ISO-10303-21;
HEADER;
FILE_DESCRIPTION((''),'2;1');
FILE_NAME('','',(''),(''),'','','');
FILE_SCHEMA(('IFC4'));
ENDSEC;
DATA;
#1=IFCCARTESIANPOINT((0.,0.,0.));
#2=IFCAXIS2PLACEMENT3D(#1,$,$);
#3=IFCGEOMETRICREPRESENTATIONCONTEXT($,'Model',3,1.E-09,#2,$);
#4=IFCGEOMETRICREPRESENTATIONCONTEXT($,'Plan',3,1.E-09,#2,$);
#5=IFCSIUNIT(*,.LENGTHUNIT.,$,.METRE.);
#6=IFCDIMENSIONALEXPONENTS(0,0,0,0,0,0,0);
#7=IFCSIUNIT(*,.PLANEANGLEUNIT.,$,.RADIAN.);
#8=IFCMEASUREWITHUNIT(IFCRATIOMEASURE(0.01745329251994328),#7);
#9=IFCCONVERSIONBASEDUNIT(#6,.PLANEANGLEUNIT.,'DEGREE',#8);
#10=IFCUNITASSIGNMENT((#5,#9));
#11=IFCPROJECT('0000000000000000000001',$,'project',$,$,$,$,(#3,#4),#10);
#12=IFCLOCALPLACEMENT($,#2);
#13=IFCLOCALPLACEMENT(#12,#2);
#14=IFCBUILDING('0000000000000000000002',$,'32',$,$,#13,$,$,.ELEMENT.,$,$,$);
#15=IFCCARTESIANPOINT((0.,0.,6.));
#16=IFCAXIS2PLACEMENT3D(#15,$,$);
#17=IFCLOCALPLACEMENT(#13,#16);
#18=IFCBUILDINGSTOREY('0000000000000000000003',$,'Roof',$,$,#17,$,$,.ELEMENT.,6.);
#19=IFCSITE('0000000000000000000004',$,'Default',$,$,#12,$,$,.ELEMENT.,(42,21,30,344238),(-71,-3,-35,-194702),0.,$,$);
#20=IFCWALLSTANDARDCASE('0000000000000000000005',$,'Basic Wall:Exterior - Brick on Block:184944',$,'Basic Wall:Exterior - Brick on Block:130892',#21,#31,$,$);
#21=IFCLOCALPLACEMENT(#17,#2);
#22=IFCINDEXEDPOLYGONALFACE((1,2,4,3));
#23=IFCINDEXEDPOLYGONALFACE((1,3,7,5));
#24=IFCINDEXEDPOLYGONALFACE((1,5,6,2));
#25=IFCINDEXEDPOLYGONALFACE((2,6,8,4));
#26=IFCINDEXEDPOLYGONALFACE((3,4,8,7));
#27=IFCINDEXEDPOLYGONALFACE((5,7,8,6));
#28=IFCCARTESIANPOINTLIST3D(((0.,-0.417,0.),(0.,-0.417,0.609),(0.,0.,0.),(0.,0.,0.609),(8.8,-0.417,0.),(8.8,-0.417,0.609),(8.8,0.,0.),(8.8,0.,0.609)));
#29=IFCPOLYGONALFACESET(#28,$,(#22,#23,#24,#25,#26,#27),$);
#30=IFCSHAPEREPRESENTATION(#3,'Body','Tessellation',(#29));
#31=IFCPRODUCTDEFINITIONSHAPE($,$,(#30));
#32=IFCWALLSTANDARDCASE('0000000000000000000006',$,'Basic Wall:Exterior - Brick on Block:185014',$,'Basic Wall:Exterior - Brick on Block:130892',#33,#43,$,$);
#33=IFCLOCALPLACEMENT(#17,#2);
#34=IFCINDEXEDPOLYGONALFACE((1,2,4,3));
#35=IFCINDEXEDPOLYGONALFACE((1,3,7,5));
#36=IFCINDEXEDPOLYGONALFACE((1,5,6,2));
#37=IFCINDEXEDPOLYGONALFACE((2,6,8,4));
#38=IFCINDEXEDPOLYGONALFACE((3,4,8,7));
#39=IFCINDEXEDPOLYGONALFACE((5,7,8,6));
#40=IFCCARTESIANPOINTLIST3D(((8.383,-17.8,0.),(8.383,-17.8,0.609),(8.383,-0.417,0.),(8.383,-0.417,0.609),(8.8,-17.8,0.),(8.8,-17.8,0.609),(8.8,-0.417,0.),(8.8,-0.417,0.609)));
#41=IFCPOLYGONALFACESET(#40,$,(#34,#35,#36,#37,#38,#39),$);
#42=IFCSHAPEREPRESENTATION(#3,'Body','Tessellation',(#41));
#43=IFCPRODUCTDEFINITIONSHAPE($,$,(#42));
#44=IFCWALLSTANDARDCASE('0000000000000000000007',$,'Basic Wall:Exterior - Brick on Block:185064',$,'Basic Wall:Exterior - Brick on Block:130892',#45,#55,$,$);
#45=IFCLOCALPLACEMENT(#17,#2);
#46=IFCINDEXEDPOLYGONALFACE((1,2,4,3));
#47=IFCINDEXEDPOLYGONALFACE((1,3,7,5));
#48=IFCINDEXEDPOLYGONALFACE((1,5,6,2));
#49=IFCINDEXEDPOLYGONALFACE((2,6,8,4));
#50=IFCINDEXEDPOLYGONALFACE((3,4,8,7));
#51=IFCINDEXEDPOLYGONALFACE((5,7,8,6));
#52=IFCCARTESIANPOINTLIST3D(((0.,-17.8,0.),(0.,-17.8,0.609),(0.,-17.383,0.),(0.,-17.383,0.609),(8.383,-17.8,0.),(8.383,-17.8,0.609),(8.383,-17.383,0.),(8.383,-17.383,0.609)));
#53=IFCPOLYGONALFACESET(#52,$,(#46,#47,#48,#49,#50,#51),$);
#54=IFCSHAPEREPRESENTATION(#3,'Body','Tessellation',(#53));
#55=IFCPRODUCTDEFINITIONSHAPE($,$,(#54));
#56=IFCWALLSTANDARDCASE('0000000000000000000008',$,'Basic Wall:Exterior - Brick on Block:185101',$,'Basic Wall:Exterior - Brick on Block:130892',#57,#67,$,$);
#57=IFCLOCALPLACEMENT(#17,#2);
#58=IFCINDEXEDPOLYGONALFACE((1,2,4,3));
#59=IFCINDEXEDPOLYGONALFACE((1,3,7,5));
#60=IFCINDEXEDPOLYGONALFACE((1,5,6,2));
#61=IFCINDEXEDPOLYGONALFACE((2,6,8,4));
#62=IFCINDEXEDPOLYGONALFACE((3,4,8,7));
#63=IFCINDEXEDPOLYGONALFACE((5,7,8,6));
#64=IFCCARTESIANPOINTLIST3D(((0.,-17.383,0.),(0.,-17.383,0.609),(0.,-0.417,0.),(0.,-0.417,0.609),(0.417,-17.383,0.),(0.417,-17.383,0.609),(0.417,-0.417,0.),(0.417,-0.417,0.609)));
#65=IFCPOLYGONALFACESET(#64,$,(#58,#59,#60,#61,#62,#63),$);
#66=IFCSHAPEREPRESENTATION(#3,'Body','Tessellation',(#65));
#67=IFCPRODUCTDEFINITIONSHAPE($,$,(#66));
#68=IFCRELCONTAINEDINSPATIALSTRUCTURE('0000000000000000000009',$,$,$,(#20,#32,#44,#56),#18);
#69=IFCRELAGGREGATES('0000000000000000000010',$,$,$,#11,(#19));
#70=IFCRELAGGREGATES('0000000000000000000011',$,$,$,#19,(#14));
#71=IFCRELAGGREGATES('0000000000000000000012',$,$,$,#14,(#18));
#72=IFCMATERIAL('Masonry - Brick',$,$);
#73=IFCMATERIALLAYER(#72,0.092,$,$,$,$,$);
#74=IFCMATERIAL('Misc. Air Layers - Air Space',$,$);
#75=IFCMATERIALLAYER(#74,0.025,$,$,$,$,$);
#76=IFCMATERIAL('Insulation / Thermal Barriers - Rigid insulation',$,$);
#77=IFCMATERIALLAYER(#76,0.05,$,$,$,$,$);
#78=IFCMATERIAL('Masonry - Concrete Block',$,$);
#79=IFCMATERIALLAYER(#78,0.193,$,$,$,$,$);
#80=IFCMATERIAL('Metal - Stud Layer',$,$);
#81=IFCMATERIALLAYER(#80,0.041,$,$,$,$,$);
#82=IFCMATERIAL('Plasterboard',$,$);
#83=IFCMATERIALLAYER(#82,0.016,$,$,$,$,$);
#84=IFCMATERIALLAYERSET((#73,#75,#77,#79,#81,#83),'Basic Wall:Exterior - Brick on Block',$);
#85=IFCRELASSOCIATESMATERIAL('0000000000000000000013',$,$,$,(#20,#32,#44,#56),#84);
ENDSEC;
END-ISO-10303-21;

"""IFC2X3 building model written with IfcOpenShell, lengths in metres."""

from ifc_helpers import new_model, entity, si_unit, converted_unit, frame, frame_2d, origin, place, context, project, spatial, rectangle, extrude, material, layer, layer_set, layer_usage, element, save


model = new_model("IFC2X3")

# Units and contexts
model_context = context("Model", 3, precision=1e-09, world=origin())
plan_context = context("Plan", 3, precision=1e-09, world=origin())
ifc_project = project(units=[si_unit("LENGTHUNIT", "METRE"), converted_unit("PLANEANGLEUNIT", "DEGREE", entity("IfcRatioMeasure", 0.01745329251994328), si_unit("PLANEANGLEUNIT", "RADIAN"), dimensions=[0, 0, 0, 0, 0, 0, 0])], contexts=[model_context, plan_context])

# Site, building, storey
site_placement = place(None, origin())
site = spatial("IfcSite", under=ifc_project, at=site_placement, Name="Default", CompositionType="ELEMENT", RefLatitude=(42, 21, 30, 344238), RefLongitude=(-71, -3, -35, -194702), RefElevation=0.0)
building_placement = place(site_placement, origin())
building = spatial("IfcBuilding", under=site, at=building_placement, Name="32", CompositionType="ELEMENT")
storey_placement = place(building_placement, frame((0.0, 0.0, 6.0)))
storey = spatial("IfcBuildingStorey", under=building, at=storey_placement, Name="Roof", CompositionType="ELEMENT", Elevation=6.0)

# Walls
ifc_material_1 = material(Name="Masonry - Brick")
ifc_layer_1 = layer(ifc_material_1, 0.092)
ifc_material_2 = material(Name="Misc. Air Layers - Air Space")
ifc_layer_2 = layer(ifc_material_2, 0.025)
ifc_material_3 = material(Name="Insulation / Thermal Barriers - Rigid insulation")
ifc_layer_3 = layer(ifc_material_3, 0.05)
ifc_material_4 = material(Name="Masonry - Concrete Block")
ifc_layer_4 = layer(ifc_material_4, 0.193)
ifc_material_5 = material(Name="Metal - Stud Layer")
ifc_layer_5 = layer(ifc_material_5, 0.041)
ifc_material_6 = material(Name="Plasterboard")
ifc_layer_6 = layer(ifc_material_6, 0.016)
ifc_layer_set = layer_set([ifc_layer_1, ifc_layer_2, ifc_layer_3, ifc_layer_4, ifc_layer_5, ifc_layer_6], Name="Basic Wall:Exterior - Brick on Block")
ifc_layer_usage_1 = layer_usage(ifc_layer_set, "AXIS2", "NEGATIVE", 0.2085)
wall_1_placement = place(storey_placement, frame((0.0, -0.2085, 0.0)))
element("IfcWallStandardCase", 1, at=wall_1_placement, inside=storey, material=ifc_layer_usage_1, Name="Basic Wall:Exterior - Brick on Block:184944", ObjectType="Basic Wall:Exterior - Brick on Block:130892", context=model_context, shape_type="SweptSolid", body=[
    extrude(rectangle(XDim=8.8, YDim=0.417, at=frame_2d((4.4, 0.0), x_axis=(-1.0, 0.0))), origin(), (0.0, 0.0, 1.0), 0.609),
])
ifc_layer_usage_2 = layer_usage(ifc_layer_set, "AXIS2", "NEGATIVE", 0.2085)
wall_2_placement = place(storey_placement, frame((8.5915, -0.417, 0.0), z_axis=(0.0, 0.0, 1.0), x_axis=(0.0, -1.0, 0.0)))
element("IfcWallStandardCase", 2, at=wall_2_placement, inside=storey, material=ifc_layer_usage_2, Name="Basic Wall:Exterior - Brick on Block:185014", ObjectType="Basic Wall:Exterior - Brick on Block:130892", context=model_context, shape_type="SweptSolid", body=[
    extrude(rectangle(XDim=17.383, YDim=0.417, at=frame_2d((8.6915, 0.0), x_axis=(-1.0, 0.0))), origin(), (0.0, 0.0, 1.0), 0.609),
])
ifc_layer_usage_3 = layer_usage(ifc_layer_set, "AXIS2", "NEGATIVE", 0.2085)
wall_3_placement = place(storey_placement, frame((8.383, -17.5915, 0.0), z_axis=(0.0, 0.0, 1.0), x_axis=(-1.0, 0.0, 0.0)))
element("IfcWallStandardCase", 3, at=wall_3_placement, inside=storey, material=ifc_layer_usage_3, Name="Basic Wall:Exterior - Brick on Block:185064", ObjectType="Basic Wall:Exterior - Brick on Block:130892", context=model_context, shape_type="SweptSolid", body=[
    extrude(rectangle(XDim=8.383, YDim=0.417, at=frame_2d((4.1915, 0.0), x_axis=(-1.0, 0.0))), origin(), (0.0, 0.0, 1.0), 0.609),
])
ifc_layer_usage_4 = layer_usage(ifc_layer_set, "AXIS2", "NEGATIVE", 0.2085)
wall_4_placement = place(storey_placement, frame((0.2085, -17.383, 0.0), z_axis=(0.0, 0.0, 1.0), x_axis=(0.0, 1.0, 0.0)))
element("IfcWallStandardCase", 4, at=wall_4_placement, inside=storey, material=ifc_layer_usage_4, Name="Basic Wall:Exterior - Brick on Block:185101", ObjectType="Basic Wall:Exterior - Brick on Block:130892", context=model_context, shape_type="SweptSolid", body=[
    extrude(rectangle(XDim=16.966, YDim=0.417, at=frame_2d((8.483, 0.0), x_axis=(-1.0, 0.0))), origin(), (0.0, 0.0, 1.0), 0.609),
])

save(model, "model.ifc")
